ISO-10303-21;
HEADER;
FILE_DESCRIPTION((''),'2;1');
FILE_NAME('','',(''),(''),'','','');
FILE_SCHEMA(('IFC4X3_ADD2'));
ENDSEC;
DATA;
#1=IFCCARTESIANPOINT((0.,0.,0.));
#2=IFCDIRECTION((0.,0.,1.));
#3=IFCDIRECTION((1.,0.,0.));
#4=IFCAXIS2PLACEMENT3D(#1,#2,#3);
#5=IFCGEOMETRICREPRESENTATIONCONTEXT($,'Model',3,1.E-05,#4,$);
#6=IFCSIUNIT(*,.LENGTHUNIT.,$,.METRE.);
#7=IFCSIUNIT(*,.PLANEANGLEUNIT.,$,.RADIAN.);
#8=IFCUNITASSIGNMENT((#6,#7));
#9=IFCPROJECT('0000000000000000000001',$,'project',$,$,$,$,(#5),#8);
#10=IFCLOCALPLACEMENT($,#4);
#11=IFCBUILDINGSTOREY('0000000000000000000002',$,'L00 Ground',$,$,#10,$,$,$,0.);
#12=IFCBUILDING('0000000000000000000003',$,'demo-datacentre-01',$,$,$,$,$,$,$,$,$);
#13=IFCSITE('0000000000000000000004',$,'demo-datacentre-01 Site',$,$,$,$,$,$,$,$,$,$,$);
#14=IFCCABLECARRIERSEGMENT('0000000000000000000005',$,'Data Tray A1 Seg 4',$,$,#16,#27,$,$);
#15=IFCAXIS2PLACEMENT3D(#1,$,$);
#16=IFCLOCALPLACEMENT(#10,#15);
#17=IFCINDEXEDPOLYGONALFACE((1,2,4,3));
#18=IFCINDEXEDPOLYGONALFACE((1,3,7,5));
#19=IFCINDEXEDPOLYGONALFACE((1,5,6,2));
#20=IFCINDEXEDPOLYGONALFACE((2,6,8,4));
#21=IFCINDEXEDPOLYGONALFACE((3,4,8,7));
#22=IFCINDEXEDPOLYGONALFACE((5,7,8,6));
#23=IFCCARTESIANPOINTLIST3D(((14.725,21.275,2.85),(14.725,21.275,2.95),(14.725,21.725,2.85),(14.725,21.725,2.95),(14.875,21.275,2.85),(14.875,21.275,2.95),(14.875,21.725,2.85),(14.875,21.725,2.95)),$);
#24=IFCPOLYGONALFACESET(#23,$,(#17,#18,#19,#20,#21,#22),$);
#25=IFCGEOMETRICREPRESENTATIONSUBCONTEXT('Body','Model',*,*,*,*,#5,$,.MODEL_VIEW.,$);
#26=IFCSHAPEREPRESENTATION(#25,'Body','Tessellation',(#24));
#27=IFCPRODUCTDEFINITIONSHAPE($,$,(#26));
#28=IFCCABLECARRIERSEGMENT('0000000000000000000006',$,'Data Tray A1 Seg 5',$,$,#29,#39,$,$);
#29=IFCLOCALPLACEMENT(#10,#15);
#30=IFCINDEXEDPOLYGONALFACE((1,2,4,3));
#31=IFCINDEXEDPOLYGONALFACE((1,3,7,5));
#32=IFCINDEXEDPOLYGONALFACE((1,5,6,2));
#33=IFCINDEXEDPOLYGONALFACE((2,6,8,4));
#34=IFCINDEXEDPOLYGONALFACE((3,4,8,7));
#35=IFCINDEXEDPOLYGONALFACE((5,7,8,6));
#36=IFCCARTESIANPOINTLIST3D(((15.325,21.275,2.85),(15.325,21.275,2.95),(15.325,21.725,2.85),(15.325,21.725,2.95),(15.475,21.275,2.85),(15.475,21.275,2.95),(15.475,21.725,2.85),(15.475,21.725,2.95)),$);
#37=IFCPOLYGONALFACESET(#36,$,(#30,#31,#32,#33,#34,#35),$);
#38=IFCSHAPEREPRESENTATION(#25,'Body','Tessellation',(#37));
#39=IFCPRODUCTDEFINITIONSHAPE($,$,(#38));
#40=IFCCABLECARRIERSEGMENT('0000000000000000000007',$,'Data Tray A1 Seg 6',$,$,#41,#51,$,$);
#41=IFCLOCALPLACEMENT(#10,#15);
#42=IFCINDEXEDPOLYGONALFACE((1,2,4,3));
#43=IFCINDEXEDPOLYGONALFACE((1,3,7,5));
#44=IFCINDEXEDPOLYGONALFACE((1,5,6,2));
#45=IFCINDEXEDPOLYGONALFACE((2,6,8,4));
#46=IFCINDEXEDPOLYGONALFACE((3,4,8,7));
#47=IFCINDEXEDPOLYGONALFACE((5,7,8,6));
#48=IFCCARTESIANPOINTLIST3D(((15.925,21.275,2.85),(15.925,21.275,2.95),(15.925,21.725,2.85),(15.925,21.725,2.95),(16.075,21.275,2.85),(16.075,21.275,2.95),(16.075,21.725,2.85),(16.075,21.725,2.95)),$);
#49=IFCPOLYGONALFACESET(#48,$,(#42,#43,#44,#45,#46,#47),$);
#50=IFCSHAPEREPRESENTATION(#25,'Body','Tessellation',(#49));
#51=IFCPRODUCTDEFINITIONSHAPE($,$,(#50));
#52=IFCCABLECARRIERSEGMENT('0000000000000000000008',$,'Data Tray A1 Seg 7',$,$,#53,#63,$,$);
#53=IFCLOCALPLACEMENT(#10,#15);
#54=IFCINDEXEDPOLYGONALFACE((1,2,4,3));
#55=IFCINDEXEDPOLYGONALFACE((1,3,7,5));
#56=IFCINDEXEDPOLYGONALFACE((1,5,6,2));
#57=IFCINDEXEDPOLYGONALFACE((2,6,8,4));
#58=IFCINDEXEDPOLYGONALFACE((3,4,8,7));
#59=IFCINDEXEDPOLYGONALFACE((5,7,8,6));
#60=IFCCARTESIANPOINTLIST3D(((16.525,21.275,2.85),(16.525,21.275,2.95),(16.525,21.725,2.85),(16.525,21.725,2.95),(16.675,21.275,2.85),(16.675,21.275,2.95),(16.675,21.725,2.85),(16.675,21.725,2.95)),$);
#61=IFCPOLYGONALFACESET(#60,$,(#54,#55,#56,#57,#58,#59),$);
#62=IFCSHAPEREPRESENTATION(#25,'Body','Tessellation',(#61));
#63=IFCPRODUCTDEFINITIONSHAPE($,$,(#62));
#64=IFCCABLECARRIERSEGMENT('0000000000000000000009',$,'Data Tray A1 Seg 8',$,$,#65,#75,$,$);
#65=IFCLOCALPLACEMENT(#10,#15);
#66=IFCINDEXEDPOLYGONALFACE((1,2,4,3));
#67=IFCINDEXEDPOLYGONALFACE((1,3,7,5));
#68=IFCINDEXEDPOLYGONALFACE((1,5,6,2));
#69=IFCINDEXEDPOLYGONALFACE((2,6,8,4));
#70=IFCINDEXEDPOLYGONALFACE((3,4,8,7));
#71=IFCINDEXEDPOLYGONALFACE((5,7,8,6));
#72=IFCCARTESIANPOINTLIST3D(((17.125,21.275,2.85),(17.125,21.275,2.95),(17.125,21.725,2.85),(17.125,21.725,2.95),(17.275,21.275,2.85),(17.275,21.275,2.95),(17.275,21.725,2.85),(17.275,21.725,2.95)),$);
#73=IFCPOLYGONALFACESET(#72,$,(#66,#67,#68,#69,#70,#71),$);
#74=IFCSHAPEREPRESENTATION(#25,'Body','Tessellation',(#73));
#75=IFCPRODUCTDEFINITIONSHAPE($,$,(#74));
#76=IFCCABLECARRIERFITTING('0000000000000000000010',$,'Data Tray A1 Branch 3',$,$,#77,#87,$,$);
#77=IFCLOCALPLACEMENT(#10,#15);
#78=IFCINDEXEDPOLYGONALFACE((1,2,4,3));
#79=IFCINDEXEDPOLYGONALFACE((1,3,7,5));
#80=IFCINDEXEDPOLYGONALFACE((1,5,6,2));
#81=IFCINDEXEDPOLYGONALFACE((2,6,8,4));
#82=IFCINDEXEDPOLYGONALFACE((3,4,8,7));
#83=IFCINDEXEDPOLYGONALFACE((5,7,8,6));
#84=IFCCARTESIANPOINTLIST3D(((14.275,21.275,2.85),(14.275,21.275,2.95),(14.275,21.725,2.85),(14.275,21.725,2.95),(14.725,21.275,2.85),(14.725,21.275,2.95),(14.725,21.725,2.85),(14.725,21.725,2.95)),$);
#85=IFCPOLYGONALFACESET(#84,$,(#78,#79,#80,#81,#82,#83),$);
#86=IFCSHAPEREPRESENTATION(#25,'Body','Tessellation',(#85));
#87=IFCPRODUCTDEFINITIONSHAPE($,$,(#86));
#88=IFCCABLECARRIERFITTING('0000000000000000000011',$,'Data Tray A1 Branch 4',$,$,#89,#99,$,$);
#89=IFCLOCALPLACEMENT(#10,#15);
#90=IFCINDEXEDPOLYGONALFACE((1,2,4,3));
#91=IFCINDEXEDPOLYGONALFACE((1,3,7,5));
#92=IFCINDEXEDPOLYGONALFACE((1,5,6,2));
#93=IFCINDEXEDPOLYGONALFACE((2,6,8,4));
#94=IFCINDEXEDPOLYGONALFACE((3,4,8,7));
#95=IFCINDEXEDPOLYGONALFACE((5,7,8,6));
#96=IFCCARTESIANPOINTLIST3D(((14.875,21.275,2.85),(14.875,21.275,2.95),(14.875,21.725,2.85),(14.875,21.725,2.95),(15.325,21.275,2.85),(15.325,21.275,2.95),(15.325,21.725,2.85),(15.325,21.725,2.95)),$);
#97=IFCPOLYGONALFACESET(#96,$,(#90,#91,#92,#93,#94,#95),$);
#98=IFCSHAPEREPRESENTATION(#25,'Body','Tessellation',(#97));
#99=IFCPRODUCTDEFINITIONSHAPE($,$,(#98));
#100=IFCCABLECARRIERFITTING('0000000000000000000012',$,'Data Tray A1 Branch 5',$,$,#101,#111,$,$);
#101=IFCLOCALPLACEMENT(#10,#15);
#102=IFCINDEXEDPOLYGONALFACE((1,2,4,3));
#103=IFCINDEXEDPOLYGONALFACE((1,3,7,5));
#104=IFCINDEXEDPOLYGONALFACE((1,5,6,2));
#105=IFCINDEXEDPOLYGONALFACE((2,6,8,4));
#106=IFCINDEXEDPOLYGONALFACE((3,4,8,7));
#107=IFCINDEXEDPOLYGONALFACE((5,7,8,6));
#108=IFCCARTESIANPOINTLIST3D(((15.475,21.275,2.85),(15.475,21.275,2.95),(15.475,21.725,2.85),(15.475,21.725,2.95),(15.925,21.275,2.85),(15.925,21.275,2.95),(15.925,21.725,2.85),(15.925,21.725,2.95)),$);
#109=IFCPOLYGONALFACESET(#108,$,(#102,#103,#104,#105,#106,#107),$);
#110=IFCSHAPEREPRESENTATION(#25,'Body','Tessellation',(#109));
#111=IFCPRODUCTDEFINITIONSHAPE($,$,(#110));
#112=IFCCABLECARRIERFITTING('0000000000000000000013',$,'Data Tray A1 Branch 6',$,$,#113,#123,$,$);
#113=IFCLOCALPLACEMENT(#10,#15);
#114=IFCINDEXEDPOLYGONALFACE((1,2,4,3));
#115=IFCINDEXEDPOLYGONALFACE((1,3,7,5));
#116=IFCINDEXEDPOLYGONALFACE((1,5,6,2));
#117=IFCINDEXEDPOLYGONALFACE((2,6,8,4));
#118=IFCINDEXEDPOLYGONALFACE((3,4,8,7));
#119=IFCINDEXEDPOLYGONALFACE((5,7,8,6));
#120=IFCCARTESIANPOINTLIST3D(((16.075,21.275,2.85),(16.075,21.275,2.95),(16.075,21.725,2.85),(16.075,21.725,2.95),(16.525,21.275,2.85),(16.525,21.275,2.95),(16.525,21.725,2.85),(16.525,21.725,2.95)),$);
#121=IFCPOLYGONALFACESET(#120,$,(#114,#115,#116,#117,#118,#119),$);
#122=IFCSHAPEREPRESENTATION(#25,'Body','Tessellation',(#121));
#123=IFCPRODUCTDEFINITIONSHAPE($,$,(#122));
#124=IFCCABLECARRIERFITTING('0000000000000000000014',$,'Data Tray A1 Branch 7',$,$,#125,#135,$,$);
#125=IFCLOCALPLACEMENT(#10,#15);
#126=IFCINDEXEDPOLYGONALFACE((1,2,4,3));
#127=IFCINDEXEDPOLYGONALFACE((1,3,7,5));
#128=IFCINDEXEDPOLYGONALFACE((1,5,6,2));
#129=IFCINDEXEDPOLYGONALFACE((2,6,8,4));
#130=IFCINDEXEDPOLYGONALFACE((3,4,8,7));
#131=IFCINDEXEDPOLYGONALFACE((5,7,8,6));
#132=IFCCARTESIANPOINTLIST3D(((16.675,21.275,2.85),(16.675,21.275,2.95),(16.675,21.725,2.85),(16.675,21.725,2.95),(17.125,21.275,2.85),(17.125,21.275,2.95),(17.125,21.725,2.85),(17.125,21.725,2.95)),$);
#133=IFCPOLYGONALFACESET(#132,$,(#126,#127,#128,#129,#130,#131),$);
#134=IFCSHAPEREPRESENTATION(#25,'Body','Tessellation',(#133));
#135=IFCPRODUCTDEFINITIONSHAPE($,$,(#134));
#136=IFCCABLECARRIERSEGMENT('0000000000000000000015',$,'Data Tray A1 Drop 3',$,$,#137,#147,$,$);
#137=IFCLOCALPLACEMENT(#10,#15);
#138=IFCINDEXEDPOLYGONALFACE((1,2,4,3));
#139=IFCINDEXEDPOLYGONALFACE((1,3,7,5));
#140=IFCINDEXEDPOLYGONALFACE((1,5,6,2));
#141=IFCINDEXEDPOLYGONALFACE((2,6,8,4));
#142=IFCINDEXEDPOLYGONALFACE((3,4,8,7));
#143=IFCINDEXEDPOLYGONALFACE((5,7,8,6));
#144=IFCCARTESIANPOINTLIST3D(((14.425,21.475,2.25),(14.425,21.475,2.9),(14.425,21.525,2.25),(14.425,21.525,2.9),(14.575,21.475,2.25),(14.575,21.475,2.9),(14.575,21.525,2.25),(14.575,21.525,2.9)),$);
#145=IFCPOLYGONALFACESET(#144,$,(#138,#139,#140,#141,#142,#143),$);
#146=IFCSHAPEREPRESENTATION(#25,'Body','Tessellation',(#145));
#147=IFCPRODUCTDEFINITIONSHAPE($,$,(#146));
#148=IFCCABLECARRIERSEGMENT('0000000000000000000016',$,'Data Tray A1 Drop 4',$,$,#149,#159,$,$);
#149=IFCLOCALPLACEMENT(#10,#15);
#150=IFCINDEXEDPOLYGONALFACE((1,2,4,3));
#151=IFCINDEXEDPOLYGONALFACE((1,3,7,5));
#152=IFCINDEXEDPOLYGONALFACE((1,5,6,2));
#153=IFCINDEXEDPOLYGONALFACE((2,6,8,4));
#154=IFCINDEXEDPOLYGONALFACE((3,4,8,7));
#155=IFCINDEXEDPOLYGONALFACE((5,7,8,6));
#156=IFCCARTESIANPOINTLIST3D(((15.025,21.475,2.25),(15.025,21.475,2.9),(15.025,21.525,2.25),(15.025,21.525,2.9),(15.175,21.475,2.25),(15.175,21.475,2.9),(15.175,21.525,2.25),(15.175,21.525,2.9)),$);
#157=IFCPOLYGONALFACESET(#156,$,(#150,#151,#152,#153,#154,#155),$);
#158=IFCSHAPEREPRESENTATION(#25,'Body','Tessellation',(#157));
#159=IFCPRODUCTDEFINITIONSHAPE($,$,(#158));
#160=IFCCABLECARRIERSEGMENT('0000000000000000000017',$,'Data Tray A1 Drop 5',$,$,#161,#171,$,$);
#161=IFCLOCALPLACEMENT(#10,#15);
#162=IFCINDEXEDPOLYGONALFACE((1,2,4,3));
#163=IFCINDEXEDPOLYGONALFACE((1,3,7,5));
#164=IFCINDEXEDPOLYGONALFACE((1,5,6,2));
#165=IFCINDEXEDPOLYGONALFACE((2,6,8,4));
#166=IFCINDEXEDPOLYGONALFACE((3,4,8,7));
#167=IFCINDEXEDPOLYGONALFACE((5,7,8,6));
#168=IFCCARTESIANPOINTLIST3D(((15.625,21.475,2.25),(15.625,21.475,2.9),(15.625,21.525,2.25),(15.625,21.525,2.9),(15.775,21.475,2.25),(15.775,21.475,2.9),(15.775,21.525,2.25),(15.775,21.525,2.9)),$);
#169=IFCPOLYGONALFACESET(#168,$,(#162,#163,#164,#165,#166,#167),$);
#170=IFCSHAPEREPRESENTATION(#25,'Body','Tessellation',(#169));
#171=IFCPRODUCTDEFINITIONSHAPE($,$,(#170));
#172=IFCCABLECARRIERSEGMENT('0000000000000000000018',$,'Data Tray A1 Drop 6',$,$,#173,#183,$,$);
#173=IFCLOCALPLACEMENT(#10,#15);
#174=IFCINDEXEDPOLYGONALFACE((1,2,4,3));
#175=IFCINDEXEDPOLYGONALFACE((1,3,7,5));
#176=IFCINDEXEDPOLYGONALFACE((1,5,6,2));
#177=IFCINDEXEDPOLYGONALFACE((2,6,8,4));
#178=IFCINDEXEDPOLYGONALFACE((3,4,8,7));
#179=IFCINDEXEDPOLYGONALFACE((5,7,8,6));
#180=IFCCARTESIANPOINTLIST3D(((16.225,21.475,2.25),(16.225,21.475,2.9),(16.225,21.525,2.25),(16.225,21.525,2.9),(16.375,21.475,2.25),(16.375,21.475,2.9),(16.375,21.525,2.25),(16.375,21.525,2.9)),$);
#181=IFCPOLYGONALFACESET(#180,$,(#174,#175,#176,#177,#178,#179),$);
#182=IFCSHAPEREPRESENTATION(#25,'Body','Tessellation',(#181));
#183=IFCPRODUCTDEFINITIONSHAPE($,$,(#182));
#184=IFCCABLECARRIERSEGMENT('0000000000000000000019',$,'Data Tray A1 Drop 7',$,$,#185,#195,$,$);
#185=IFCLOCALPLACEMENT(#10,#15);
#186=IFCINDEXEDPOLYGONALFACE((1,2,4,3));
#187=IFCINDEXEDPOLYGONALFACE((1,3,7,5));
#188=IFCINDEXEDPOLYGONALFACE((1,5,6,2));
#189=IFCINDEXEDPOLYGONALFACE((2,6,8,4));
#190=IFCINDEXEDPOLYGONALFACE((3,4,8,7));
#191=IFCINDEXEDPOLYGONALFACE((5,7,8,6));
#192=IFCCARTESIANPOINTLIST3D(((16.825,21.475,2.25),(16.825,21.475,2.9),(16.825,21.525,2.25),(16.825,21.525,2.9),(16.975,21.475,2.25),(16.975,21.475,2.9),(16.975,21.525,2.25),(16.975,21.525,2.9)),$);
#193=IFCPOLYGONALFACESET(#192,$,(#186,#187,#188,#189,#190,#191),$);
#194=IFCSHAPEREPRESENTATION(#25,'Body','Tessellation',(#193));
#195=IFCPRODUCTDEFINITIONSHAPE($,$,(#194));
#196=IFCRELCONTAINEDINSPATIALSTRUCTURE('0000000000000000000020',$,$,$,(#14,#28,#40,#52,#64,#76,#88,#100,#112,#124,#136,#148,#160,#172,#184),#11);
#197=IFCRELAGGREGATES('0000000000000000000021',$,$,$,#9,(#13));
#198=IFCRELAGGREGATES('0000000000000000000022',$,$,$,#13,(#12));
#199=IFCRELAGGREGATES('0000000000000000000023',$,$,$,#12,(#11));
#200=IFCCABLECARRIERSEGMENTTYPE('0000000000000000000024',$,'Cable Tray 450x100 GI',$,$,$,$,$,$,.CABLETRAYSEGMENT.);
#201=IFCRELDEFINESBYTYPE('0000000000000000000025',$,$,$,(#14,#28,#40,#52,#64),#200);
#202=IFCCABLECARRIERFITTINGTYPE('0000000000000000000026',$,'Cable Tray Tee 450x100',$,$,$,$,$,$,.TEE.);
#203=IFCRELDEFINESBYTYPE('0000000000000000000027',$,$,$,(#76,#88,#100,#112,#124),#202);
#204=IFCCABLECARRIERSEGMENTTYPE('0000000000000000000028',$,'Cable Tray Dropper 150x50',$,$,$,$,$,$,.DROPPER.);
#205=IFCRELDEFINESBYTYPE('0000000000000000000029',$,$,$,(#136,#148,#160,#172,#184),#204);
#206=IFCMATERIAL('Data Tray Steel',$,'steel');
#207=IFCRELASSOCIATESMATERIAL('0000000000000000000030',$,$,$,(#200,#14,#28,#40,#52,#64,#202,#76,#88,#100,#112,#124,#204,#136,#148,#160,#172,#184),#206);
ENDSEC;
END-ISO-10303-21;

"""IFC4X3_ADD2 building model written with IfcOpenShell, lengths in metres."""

from ifc_helpers import new_model, si_unit, frame, origin_with_axes, place, context, subcontext, project, spatial, rectangle, extrude, material, type_object, element, save


model = new_model("IFC4X3_ADD2")

# Units and contexts
model_context = context("Model", 3, precision=1e-05, world=origin_with_axes())
body_context = subcontext(model_context, "Body", "Model", "MODEL_VIEW")
ifc_project = project(units=[si_unit("LENGTHUNIT", "METRE"), si_unit("PLANEANGLEUNIT", "RADIAN")], contexts=[model_context])

# Site, building, storey
site = spatial("IfcSite", under=ifc_project, Name="demo-datacentre-01 Site")
building = spatial("IfcBuilding", under=site, Name="demo-datacentre-01")
storey_placement = place(None, origin_with_axes())
storey = spatial("IfcBuildingStorey", under=building, at=storey_placement, Name="L00 Ground", Elevation=0.0)

# Cable carrier segments
ifc_material_1 = material(Name="Data Tray Steel", Category="steel")
cable_carrier_segment_type_1 = type_object("IfcCableCarrierSegmentType", Name="Cable Tray 450x100 GI", PredefinedType="CABLETRAYSEGMENT", material=ifc_material_1)
cable_carrier_segment_1_placement = place(storey_placement, frame((14.725, 21.5, 2.9), z_axis=(1.0, 0.0, 0.0), x_axis=(0.0, 1.0, 0.0)))
element("IfcCableCarrierSegment", 1, at=cable_carrier_segment_1_placement, inside=storey, type_object=cable_carrier_segment_type_1, material=ifc_material_1, Name="Data Tray A1 Seg 4", context=body_context, shape_type="SweptSolid", body=[
    extrude(rectangle(XDim=0.45, YDim=0.1), origin_with_axes(), (0.0, 0.0, 1.0), 0.15),
])
cable_carrier_segment_2_placement = place(storey_placement, frame((15.325, 21.5, 2.9), z_axis=(1.0, 0.0, 0.0), x_axis=(0.0, 1.0, 0.0)))
element("IfcCableCarrierSegment", 2, at=cable_carrier_segment_2_placement, inside=storey, type_object=cable_carrier_segment_type_1, material=ifc_material_1, Name="Data Tray A1 Seg 5", context=body_context, shape_type="SweptSolid", body=[
    extrude(rectangle(XDim=0.45, YDim=0.1), origin_with_axes(), (0.0, 0.0, 1.0), 0.15),
])
cable_carrier_segment_3_placement = place(storey_placement, frame((15.925, 21.5, 2.9), z_axis=(1.0, 0.0, 0.0), x_axis=(0.0, 1.0, 0.0)))
element("IfcCableCarrierSegment", 3, at=cable_carrier_segment_3_placement, inside=storey, type_object=cable_carrier_segment_type_1, material=ifc_material_1, Name="Data Tray A1 Seg 6", context=body_context, shape_type="SweptSolid", body=[
    extrude(rectangle(XDim=0.45, YDim=0.1), origin_with_axes(), (0.0, 0.0, 1.0), 0.15),
])
cable_carrier_segment_4_placement = place(storey_placement, frame((16.525, 21.5, 2.9), z_axis=(1.0, 0.0, 0.0), x_axis=(0.0, 1.0, 0.0)))
element("IfcCableCarrierSegment", 4, at=cable_carrier_segment_4_placement, inside=storey, type_object=cable_carrier_segment_type_1, material=ifc_material_1, Name="Data Tray A1 Seg 7", context=body_context, shape_type="SweptSolid", body=[
    extrude(rectangle(XDim=0.45, YDim=0.1), origin_with_axes(), (0.0, 0.0, 1.0), 0.15),
])
cable_carrier_segment_5_placement = place(storey_placement, frame((17.125, 21.5, 2.9), z_axis=(1.0, 0.0, 0.0), x_axis=(0.0, 1.0, 0.0)))
element("IfcCableCarrierSegment", 5, at=cable_carrier_segment_5_placement, inside=storey, type_object=cable_carrier_segment_type_1, material=ifc_material_1, Name="Data Tray A1 Seg 8", context=body_context, shape_type="SweptSolid", body=[
    extrude(rectangle(XDim=0.45, YDim=0.1), origin_with_axes(), (0.0, 0.0, 1.0), 0.15),
])

# Cable carrier fittings
cable_carrier_fitting_type = type_object("IfcCableCarrierFittingType", Name="Cable Tray Tee 450x100", PredefinedType="TEE", material=ifc_material_1)
for number, where, z_axis, x_axis, name in (
    (6, (14.5, 21.5, 2.85), (0.0, 0.0, 1.0), (1.0, 0.0, 0.0), "Data Tray A1 Branch 3"),
    (7, (15.1, 21.5, 2.85), (0.0, 0.0, 1.0), (1.0, 0.0, 0.0), "Data Tray A1 Branch 4"),
    (8, (15.7, 21.5, 2.85), (0.0, 0.0, 1.0), (1.0, 0.0, 0.0), "Data Tray A1 Branch 5"),
    (9, (16.3, 21.5, 2.85), (0.0, 0.0, 1.0), (1.0, 0.0, 0.0), "Data Tray A1 Branch 6"),
    (10, (16.9, 21.5, 2.85), (0.0, 0.0, 1.0), (1.0, 0.0, 0.0), "Data Tray A1 Branch 7"),
):
    element("IfcCableCarrierFitting", number, at=place(storey_placement, frame(where, z_axis=z_axis, x_axis=x_axis)), inside=storey, type_object=cable_carrier_fitting_type, material=ifc_material_1, Name=name, context=body_context, shape_type="SweptSolid", body=[
        extrude(rectangle(XDim=0.45, YDim=0.45), origin_with_axes(), (0.0, 0.0, 1.0), 0.1),
    ])

# Cable carrier segments
cable_carrier_segment_type_2 = type_object("IfcCableCarrierSegmentType", Name="Cable Tray Dropper 150x50", PredefinedType="DROPPER", material=ifc_material_1)
for number, where, z_axis, x_axis, name in (
    (11, (14.5, 21.5, 2.9), (0.0, 0.0, -1.0), (1.0, 0.0, 0.0), "Data Tray A1 Drop 3"),
    (12, (15.1, 21.5, 2.9), (0.0, 0.0, -1.0), (1.0, 0.0, 0.0), "Data Tray A1 Drop 4"),
    (13, (15.7, 21.5, 2.9), (0.0, 0.0, -1.0), (1.0, 0.0, 0.0), "Data Tray A1 Drop 5"),
    (14, (16.3, 21.5, 2.9), (0.0, 0.0, -1.0), (1.0, 0.0, 0.0), "Data Tray A1 Drop 6"),
    (15, (16.9, 21.5, 2.9), (0.0, 0.0, -1.0), (1.0, 0.0, 0.0), "Data Tray A1 Drop 7"),
):
    element("IfcCableCarrierSegment", number, at=place(storey_placement, frame(where, z_axis=z_axis, x_axis=x_axis)), inside=storey, type_object=cable_carrier_segment_type_2, material=ifc_material_1, Name=name, context=body_context, shape_type="SweptSolid", body=[
        extrude(rectangle(XDim=0.15, YDim=0.05), origin_with_axes(), (0.0, 0.0, 1.0), 0.65),
    ])

save(model, "model.ifc")
